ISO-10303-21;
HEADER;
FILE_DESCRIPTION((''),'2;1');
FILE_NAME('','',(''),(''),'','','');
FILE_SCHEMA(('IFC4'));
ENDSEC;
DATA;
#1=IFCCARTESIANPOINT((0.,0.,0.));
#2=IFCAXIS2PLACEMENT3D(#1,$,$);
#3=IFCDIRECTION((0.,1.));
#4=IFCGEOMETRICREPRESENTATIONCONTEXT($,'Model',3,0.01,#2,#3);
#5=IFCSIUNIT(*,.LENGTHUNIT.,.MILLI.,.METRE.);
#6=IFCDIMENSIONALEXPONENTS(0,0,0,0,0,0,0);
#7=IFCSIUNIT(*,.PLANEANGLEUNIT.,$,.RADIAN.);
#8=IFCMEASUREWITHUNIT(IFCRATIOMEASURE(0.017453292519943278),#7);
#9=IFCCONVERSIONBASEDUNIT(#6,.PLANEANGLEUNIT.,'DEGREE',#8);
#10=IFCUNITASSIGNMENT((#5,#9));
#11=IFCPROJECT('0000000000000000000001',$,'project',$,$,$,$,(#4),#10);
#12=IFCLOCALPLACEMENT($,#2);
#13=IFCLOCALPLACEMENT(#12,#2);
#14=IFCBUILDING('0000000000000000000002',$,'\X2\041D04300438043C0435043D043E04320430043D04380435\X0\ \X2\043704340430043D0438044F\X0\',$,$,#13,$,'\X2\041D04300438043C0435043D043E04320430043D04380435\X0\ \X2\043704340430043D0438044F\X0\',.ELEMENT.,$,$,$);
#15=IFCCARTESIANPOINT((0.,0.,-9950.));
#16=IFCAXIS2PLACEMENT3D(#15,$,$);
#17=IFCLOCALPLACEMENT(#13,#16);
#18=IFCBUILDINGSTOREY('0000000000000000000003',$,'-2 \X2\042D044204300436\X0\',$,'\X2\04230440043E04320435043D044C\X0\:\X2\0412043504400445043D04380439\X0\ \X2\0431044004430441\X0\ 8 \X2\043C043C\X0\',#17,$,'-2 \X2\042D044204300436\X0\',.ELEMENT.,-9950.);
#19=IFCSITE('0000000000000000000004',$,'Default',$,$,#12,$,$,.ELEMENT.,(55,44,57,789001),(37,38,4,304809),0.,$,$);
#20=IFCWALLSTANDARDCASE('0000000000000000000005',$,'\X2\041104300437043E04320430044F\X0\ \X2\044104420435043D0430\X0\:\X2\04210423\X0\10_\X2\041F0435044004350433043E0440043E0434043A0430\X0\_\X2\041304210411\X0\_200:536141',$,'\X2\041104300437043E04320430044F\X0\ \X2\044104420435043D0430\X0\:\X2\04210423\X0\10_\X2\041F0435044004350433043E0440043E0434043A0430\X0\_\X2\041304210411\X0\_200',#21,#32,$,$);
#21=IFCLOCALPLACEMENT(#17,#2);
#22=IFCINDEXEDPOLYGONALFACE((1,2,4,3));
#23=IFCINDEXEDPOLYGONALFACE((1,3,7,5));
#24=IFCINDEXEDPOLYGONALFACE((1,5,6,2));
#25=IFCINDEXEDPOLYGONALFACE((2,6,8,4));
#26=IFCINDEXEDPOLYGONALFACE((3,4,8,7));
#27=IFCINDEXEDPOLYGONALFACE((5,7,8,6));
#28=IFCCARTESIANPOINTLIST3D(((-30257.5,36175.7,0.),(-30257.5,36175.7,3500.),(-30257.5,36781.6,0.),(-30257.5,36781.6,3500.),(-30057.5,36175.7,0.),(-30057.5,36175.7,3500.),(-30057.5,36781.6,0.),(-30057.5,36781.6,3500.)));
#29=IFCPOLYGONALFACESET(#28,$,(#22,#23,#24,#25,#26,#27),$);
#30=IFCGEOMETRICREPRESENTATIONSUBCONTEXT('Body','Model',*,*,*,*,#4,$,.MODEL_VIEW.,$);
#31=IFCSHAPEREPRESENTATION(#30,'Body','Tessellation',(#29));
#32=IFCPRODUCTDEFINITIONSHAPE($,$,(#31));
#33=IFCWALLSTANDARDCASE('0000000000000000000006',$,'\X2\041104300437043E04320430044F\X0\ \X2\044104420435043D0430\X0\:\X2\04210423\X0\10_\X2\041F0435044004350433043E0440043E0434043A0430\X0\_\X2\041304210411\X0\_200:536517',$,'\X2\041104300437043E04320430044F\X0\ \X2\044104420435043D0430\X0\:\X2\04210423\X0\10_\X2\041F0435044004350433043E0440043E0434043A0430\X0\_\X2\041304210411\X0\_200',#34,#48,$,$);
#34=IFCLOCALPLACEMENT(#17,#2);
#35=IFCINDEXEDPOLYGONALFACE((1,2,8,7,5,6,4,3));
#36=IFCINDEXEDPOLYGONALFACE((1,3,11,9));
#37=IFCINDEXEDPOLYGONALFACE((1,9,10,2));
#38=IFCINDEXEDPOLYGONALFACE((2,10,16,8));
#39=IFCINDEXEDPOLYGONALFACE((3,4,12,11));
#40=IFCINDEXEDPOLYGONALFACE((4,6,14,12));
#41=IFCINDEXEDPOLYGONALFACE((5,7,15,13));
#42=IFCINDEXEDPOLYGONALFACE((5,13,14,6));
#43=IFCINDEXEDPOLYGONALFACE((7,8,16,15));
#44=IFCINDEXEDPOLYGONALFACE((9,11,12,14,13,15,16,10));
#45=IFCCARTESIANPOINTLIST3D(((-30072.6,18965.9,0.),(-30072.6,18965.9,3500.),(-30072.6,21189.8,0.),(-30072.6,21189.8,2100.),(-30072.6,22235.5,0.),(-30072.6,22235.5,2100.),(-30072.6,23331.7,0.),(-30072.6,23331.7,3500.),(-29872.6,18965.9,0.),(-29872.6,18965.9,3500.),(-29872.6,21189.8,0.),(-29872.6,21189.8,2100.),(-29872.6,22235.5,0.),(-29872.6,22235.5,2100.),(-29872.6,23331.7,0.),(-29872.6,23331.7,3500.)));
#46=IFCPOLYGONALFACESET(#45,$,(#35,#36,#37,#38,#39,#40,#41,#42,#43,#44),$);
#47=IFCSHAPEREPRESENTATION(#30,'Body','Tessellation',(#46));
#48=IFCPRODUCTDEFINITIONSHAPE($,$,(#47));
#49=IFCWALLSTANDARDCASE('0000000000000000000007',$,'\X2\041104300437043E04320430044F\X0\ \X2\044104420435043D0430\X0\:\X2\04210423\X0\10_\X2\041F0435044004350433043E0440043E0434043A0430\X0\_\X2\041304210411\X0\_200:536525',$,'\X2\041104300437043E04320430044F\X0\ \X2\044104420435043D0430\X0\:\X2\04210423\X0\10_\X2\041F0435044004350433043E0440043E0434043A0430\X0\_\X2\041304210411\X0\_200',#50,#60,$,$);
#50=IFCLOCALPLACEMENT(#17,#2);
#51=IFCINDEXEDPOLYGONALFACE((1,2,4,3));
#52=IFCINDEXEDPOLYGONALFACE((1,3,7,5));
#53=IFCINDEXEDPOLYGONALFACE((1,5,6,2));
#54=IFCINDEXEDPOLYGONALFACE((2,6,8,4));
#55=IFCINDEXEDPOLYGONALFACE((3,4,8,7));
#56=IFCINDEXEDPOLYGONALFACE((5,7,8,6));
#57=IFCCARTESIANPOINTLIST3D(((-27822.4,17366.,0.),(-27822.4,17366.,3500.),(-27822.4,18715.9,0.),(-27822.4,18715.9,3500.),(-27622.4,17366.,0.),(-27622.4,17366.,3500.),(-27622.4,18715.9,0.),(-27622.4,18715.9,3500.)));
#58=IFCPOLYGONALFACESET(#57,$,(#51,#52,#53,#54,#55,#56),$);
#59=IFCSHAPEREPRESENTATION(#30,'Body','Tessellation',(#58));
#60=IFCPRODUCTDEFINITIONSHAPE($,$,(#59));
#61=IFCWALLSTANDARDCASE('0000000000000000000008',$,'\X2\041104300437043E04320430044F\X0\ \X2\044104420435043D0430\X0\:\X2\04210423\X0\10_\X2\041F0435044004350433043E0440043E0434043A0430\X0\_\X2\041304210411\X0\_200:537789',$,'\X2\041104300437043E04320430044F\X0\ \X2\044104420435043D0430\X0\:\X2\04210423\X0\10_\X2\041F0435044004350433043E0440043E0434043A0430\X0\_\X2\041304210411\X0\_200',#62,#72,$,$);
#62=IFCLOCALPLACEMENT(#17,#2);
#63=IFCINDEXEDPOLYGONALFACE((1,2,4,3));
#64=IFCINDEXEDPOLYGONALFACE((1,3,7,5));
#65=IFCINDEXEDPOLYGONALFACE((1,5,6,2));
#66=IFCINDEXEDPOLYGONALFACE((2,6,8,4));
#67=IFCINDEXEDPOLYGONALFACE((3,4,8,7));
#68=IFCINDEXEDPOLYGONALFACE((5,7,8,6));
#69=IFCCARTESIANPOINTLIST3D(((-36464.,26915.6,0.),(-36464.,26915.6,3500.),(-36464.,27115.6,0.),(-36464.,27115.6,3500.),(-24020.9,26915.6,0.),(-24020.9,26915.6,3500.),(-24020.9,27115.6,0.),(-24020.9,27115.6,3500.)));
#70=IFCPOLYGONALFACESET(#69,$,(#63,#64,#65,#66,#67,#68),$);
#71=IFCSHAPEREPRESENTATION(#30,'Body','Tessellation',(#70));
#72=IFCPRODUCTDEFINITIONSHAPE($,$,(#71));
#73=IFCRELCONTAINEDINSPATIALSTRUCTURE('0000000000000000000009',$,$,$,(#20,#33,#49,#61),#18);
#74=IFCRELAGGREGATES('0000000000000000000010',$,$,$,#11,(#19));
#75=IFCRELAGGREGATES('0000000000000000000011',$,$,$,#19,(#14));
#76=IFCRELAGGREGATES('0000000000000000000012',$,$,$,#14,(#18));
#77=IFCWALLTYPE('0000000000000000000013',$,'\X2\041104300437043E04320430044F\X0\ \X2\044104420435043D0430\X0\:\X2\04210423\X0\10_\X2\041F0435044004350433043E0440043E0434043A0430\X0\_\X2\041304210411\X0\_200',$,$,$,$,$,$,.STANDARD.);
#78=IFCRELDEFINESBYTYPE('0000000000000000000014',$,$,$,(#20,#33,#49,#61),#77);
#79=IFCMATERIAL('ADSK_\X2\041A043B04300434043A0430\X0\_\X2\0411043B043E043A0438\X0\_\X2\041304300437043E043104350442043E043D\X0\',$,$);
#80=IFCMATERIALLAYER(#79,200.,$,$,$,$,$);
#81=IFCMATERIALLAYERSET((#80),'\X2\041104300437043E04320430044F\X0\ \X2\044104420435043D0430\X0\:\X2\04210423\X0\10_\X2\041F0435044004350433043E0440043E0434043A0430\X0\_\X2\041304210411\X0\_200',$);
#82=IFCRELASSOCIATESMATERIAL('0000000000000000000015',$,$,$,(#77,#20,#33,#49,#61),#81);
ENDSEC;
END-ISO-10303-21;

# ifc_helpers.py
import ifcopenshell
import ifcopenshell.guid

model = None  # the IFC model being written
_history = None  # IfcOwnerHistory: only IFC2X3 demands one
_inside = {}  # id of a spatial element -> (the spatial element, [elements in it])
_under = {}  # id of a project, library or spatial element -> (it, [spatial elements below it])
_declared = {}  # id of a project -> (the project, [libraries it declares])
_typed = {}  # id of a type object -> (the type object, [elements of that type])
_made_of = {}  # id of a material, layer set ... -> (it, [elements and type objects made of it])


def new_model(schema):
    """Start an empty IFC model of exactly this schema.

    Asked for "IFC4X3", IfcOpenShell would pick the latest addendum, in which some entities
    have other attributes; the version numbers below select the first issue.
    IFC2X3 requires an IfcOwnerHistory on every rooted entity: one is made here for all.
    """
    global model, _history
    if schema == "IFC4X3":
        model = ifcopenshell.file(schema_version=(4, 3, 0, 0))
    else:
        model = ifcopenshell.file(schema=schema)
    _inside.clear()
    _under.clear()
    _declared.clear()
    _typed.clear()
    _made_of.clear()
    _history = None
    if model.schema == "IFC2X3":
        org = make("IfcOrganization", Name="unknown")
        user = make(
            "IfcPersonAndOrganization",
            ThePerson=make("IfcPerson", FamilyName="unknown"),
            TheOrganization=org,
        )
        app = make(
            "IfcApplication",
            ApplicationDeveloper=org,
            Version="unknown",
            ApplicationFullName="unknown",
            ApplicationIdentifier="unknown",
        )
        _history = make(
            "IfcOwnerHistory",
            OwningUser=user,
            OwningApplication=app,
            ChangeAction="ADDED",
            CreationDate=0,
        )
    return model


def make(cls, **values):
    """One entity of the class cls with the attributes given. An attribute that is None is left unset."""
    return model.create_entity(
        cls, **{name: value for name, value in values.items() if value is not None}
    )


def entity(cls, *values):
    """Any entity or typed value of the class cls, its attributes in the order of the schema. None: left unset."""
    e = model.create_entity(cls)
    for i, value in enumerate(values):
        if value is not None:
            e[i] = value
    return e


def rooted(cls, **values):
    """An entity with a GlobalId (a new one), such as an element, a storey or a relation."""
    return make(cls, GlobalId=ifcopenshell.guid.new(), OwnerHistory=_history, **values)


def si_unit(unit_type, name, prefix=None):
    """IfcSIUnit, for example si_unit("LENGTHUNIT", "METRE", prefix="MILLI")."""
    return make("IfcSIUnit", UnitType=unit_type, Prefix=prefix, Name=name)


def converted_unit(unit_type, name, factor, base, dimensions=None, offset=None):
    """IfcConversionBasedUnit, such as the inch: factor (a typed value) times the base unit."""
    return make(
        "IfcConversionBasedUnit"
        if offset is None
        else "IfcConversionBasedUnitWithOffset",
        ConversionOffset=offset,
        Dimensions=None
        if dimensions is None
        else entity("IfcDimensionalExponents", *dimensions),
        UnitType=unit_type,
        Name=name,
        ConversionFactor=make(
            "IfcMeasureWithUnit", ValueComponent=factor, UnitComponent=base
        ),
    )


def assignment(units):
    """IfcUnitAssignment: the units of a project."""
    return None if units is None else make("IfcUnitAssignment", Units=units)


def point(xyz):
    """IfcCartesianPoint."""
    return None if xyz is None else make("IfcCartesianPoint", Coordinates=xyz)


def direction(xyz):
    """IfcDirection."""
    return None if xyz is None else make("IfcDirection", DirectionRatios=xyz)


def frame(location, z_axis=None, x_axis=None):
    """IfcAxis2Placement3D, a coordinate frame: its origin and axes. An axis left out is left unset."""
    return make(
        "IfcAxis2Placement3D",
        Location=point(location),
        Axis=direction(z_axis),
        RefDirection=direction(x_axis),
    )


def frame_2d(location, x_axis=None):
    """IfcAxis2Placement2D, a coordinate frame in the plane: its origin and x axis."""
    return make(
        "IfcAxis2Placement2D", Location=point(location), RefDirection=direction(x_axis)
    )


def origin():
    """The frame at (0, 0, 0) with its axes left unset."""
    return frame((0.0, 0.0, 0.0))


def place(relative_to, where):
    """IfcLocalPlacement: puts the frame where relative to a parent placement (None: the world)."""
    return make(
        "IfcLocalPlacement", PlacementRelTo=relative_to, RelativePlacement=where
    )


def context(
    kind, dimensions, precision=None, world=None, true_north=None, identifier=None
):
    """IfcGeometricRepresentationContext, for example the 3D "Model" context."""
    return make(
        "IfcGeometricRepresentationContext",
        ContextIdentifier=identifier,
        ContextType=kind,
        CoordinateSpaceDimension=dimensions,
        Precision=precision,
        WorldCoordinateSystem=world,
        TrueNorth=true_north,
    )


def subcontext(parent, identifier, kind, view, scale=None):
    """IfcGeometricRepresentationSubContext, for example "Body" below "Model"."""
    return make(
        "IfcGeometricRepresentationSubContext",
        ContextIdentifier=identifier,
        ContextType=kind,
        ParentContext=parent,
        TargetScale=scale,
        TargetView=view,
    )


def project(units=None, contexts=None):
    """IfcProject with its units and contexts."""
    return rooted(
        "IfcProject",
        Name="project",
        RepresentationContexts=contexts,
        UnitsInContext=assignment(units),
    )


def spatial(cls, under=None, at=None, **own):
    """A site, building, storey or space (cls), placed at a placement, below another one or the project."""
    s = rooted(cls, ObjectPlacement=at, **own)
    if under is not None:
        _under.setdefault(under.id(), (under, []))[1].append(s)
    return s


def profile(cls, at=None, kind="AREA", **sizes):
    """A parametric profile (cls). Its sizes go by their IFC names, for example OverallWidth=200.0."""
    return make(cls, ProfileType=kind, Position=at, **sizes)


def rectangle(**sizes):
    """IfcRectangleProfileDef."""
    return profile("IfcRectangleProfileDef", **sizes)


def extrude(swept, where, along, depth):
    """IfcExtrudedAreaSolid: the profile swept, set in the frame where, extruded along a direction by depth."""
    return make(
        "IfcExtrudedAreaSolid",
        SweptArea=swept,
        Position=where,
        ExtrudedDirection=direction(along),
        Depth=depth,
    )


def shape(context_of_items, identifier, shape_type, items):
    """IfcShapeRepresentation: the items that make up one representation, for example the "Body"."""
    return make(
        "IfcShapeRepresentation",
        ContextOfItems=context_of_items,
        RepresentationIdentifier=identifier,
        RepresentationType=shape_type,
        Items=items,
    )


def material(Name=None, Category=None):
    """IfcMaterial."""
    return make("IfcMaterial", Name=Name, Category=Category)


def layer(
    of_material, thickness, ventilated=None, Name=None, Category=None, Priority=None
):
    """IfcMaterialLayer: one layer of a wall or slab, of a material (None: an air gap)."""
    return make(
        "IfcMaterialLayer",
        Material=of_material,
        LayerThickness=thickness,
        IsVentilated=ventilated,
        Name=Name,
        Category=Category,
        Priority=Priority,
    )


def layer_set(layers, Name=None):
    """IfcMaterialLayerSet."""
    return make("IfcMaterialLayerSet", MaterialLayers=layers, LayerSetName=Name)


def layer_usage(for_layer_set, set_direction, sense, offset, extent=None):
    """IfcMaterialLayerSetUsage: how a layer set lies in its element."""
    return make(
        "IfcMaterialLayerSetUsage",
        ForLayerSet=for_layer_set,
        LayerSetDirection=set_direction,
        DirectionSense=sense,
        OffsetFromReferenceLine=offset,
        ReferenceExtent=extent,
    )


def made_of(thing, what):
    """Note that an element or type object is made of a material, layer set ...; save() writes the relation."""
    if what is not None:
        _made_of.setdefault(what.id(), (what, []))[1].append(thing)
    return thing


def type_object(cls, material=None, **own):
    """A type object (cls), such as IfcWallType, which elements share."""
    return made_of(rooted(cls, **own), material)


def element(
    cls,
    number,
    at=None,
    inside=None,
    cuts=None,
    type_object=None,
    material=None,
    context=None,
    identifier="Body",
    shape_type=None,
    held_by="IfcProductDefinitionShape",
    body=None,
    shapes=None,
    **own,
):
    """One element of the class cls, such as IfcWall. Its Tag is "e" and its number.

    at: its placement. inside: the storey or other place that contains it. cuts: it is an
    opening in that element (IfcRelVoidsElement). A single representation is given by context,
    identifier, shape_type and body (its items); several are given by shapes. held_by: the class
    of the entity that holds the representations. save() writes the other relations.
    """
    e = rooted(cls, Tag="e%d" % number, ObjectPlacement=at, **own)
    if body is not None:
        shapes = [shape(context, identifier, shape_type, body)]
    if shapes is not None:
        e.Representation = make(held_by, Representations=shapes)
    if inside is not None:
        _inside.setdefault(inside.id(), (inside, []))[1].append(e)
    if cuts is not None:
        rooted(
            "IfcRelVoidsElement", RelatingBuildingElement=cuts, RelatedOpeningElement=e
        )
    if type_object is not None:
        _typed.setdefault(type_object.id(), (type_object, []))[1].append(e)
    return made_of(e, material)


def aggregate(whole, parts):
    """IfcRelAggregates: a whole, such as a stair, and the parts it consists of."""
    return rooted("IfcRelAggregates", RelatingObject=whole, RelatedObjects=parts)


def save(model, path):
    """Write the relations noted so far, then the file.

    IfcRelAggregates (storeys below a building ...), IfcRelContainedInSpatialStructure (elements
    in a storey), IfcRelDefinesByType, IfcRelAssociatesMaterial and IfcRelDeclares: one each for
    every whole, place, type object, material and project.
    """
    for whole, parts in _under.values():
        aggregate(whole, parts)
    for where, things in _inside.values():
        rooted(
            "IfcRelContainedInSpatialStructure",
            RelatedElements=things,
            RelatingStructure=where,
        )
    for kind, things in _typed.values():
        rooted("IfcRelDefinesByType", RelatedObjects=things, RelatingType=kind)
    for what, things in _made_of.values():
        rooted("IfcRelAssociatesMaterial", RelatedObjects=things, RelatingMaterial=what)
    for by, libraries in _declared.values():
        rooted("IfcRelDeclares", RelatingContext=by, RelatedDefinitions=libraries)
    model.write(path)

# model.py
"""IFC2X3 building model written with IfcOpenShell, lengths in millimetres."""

from ifc_helpers import new_model, entity, si_unit, converted_unit, direction, frame, frame_2d, origin, place, context, subcontext, project, spatial, rectangle, extrude, material, layer, layer_set, layer_usage, type_object, element, save


model = new_model("IFC2X3")

# Units and contexts
model_context = context("Model", 3, precision=0.01, world=origin(), true_north=direction((0.0, 1.0)))
body_context = subcontext(model_context, "Body", "Model", "MODEL_VIEW")
ifc_project = project(units=[si_unit("LENGTHUNIT", "METRE", prefix="MILLI"), converted_unit("PLANEANGLEUNIT", "DEGREE", entity("IfcRatioMeasure", 0.017453292519943278), si_unit("PLANEANGLEUNIT", "RADIAN"), dimensions=[0, 0, 0, 0, 0, 0, 0])], contexts=[model_context])

# Site, building, storey
site_placement = place(None, origin())
site = spatial("IfcSite", under=ifc_project, at=site_placement, Name="Default", CompositionType="ELEMENT", RefLatitude=(55, 44, 57, 789001), RefLongitude=(37, 38, 4, 304809), RefElevation=0.0)
building_placement = place(site_placement, origin())
building = spatial("IfcBuilding", under=site, at=building_placement, Name="Наименование здания", LongName="Наименование здания", CompositionType="ELEMENT")
storey_placement = place(building_placement, frame((0.0, 0.0, -9950.0)))
storey = spatial("IfcBuildingStorey", under=building, at=storey_placement, Name="-2 Этаж", ObjectType="Уровень:Верхний брус 8 мм", LongName="-2 Этаж", CompositionType="ELEMENT", Elevation=-9950.0)

# Wall
ifc_material_1 = material(Name="ADSK_Кладка_Блоки_Газобетон")
ifc_layer_1 = layer(ifc_material_1, 200.0)
ifc_layer_set_1 = layer_set([ifc_layer_1], Name="Базовая стена:СУ10_Перегородка_ГСБ_200")
ifc_layer_usage_1 = layer_usage(ifc_layer_set_1, "AXIS2", "NEGATIVE", 100.0)
wall_type_1 = type_object("IfcWallType", Name="Базовая стена:СУ10_Перегородка_ГСБ_200", PredefinedType="STANDARD", material=ifc_layer_set_1)
wall_1_placement = place(storey_placement, frame((-30157.5, 36175.7, 0.0), z_axis=(0.0, 0.0, 1.0), x_axis=(0.0, 1.0, 0.0)))
element("IfcWallStandardCase", 1, at=wall_1_placement, inside=storey, type_object=wall_type_1, material=ifc_layer_usage_1, Name="Базовая стена:СУ10_Перегородка_ГСБ_200:536141", ObjectType="Базовая стена:СУ10_Перегородка_ГСБ_200", context=body_context, shape_type="SweptSolid", body=[
    extrude(rectangle(XDim=606.0, YDim=200.0, at=frame_2d((303.0, 0.0), x_axis=(-1.0, 0.0))), origin(), (0.0, 0.0, 1.0), 3500.0),
])

# Wall, opening
wall_2_placement = place(storey_placement, frame((-29972.6, 18965.9, 0.0), z_axis=(0.0, 0.0, 1.0), x_axis=(0.0, 1.0, 0.0)))
wall_2 = element("IfcWallStandardCase", 2, at=wall_2_placement, inside=storey, type_object=wall_type_1, material=ifc_layer_usage_1, Name="Базовая стена:СУ10_Перегородка_ГСБ_200:536517", ObjectType="Базовая стена:СУ10_Перегородка_ГСБ_200", context=body_context, shape_type="SweptSolid", body=[
    extrude(rectangle(XDim=4365.8, YDim=200.0, at=frame_2d((2182.9, 0.0), x_axis=(-1.0, 0.0))), origin(), (0.0, 0.0, 1.0), 3500.0),
])
opening_1_placement = place(wall_2_placement, origin())
element("IfcOpeningElement", 3, at=opening_1_placement, cuts=wall_2, ObjectType="Opening", context=body_context, shape_type="SweptSolid", body=[
    extrude(rectangle(XDim=2100.0, YDim=1045.6, at=frame_2d((0.0, 0.0), x_axis=(1.0, 0.0))), frame((2746.7, -100.0, 1050.0), z_axis=(0.0, 1.0, 0.0), x_axis=(0.0, 0.0, -1.0)), (0.0, 0.0, 1.0), 200.0),
])

# Walls
wall_3_placement = place(storey_placement, frame((-27722.4, 17366.0, 0.0), z_axis=(0.0, 0.0, 1.0), x_axis=(0.0, 1.0, 0.0)))
element("IfcWallStandardCase", 4, at=wall_3_placement, inside=storey, type_object=wall_type_1, material=ifc_layer_usage_1, Name="Базовая стена:СУ10_Перегородка_ГСБ_200:536525", ObjectType="Базовая стена:СУ10_Перегородка_ГСБ_200", context=body_context, shape_type="SweptSolid", body=[
    extrude(rectangle(XDim=1350.0, YDim=200.0, at=frame_2d((675.0, 0.0), x_axis=(-1.0, 0.0))), origin(), (0.0, 0.0, 1.0), 3500.0),
])
wall_4_placement = place(storey_placement, frame((-24020.9, 27015.6, 0.0), z_axis=(0.0, 0.0, 1.0), x_axis=(-1.0, 0.0, 0.0)))
element("IfcWallStandardCase", 5, at=wall_4_placement, inside=storey, type_object=wall_type_1, material=ifc_layer_usage_1, Name="Базовая стена:СУ10_Перегородка_ГСБ_200:537789", ObjectType="Базовая стена:СУ10_Перегородка_ГСБ_200", context=body_context, shape_type="SweptSolid", body=[
    extrude(rectangle(XDim=12443.0, YDim=200.0, at=frame_2d((6221.5, 0.0), x_axis=(-1.0, 0.0))), origin(), (0.0, 0.0, 1.0), 3500.0),
])

save(model, "model.ifc")
